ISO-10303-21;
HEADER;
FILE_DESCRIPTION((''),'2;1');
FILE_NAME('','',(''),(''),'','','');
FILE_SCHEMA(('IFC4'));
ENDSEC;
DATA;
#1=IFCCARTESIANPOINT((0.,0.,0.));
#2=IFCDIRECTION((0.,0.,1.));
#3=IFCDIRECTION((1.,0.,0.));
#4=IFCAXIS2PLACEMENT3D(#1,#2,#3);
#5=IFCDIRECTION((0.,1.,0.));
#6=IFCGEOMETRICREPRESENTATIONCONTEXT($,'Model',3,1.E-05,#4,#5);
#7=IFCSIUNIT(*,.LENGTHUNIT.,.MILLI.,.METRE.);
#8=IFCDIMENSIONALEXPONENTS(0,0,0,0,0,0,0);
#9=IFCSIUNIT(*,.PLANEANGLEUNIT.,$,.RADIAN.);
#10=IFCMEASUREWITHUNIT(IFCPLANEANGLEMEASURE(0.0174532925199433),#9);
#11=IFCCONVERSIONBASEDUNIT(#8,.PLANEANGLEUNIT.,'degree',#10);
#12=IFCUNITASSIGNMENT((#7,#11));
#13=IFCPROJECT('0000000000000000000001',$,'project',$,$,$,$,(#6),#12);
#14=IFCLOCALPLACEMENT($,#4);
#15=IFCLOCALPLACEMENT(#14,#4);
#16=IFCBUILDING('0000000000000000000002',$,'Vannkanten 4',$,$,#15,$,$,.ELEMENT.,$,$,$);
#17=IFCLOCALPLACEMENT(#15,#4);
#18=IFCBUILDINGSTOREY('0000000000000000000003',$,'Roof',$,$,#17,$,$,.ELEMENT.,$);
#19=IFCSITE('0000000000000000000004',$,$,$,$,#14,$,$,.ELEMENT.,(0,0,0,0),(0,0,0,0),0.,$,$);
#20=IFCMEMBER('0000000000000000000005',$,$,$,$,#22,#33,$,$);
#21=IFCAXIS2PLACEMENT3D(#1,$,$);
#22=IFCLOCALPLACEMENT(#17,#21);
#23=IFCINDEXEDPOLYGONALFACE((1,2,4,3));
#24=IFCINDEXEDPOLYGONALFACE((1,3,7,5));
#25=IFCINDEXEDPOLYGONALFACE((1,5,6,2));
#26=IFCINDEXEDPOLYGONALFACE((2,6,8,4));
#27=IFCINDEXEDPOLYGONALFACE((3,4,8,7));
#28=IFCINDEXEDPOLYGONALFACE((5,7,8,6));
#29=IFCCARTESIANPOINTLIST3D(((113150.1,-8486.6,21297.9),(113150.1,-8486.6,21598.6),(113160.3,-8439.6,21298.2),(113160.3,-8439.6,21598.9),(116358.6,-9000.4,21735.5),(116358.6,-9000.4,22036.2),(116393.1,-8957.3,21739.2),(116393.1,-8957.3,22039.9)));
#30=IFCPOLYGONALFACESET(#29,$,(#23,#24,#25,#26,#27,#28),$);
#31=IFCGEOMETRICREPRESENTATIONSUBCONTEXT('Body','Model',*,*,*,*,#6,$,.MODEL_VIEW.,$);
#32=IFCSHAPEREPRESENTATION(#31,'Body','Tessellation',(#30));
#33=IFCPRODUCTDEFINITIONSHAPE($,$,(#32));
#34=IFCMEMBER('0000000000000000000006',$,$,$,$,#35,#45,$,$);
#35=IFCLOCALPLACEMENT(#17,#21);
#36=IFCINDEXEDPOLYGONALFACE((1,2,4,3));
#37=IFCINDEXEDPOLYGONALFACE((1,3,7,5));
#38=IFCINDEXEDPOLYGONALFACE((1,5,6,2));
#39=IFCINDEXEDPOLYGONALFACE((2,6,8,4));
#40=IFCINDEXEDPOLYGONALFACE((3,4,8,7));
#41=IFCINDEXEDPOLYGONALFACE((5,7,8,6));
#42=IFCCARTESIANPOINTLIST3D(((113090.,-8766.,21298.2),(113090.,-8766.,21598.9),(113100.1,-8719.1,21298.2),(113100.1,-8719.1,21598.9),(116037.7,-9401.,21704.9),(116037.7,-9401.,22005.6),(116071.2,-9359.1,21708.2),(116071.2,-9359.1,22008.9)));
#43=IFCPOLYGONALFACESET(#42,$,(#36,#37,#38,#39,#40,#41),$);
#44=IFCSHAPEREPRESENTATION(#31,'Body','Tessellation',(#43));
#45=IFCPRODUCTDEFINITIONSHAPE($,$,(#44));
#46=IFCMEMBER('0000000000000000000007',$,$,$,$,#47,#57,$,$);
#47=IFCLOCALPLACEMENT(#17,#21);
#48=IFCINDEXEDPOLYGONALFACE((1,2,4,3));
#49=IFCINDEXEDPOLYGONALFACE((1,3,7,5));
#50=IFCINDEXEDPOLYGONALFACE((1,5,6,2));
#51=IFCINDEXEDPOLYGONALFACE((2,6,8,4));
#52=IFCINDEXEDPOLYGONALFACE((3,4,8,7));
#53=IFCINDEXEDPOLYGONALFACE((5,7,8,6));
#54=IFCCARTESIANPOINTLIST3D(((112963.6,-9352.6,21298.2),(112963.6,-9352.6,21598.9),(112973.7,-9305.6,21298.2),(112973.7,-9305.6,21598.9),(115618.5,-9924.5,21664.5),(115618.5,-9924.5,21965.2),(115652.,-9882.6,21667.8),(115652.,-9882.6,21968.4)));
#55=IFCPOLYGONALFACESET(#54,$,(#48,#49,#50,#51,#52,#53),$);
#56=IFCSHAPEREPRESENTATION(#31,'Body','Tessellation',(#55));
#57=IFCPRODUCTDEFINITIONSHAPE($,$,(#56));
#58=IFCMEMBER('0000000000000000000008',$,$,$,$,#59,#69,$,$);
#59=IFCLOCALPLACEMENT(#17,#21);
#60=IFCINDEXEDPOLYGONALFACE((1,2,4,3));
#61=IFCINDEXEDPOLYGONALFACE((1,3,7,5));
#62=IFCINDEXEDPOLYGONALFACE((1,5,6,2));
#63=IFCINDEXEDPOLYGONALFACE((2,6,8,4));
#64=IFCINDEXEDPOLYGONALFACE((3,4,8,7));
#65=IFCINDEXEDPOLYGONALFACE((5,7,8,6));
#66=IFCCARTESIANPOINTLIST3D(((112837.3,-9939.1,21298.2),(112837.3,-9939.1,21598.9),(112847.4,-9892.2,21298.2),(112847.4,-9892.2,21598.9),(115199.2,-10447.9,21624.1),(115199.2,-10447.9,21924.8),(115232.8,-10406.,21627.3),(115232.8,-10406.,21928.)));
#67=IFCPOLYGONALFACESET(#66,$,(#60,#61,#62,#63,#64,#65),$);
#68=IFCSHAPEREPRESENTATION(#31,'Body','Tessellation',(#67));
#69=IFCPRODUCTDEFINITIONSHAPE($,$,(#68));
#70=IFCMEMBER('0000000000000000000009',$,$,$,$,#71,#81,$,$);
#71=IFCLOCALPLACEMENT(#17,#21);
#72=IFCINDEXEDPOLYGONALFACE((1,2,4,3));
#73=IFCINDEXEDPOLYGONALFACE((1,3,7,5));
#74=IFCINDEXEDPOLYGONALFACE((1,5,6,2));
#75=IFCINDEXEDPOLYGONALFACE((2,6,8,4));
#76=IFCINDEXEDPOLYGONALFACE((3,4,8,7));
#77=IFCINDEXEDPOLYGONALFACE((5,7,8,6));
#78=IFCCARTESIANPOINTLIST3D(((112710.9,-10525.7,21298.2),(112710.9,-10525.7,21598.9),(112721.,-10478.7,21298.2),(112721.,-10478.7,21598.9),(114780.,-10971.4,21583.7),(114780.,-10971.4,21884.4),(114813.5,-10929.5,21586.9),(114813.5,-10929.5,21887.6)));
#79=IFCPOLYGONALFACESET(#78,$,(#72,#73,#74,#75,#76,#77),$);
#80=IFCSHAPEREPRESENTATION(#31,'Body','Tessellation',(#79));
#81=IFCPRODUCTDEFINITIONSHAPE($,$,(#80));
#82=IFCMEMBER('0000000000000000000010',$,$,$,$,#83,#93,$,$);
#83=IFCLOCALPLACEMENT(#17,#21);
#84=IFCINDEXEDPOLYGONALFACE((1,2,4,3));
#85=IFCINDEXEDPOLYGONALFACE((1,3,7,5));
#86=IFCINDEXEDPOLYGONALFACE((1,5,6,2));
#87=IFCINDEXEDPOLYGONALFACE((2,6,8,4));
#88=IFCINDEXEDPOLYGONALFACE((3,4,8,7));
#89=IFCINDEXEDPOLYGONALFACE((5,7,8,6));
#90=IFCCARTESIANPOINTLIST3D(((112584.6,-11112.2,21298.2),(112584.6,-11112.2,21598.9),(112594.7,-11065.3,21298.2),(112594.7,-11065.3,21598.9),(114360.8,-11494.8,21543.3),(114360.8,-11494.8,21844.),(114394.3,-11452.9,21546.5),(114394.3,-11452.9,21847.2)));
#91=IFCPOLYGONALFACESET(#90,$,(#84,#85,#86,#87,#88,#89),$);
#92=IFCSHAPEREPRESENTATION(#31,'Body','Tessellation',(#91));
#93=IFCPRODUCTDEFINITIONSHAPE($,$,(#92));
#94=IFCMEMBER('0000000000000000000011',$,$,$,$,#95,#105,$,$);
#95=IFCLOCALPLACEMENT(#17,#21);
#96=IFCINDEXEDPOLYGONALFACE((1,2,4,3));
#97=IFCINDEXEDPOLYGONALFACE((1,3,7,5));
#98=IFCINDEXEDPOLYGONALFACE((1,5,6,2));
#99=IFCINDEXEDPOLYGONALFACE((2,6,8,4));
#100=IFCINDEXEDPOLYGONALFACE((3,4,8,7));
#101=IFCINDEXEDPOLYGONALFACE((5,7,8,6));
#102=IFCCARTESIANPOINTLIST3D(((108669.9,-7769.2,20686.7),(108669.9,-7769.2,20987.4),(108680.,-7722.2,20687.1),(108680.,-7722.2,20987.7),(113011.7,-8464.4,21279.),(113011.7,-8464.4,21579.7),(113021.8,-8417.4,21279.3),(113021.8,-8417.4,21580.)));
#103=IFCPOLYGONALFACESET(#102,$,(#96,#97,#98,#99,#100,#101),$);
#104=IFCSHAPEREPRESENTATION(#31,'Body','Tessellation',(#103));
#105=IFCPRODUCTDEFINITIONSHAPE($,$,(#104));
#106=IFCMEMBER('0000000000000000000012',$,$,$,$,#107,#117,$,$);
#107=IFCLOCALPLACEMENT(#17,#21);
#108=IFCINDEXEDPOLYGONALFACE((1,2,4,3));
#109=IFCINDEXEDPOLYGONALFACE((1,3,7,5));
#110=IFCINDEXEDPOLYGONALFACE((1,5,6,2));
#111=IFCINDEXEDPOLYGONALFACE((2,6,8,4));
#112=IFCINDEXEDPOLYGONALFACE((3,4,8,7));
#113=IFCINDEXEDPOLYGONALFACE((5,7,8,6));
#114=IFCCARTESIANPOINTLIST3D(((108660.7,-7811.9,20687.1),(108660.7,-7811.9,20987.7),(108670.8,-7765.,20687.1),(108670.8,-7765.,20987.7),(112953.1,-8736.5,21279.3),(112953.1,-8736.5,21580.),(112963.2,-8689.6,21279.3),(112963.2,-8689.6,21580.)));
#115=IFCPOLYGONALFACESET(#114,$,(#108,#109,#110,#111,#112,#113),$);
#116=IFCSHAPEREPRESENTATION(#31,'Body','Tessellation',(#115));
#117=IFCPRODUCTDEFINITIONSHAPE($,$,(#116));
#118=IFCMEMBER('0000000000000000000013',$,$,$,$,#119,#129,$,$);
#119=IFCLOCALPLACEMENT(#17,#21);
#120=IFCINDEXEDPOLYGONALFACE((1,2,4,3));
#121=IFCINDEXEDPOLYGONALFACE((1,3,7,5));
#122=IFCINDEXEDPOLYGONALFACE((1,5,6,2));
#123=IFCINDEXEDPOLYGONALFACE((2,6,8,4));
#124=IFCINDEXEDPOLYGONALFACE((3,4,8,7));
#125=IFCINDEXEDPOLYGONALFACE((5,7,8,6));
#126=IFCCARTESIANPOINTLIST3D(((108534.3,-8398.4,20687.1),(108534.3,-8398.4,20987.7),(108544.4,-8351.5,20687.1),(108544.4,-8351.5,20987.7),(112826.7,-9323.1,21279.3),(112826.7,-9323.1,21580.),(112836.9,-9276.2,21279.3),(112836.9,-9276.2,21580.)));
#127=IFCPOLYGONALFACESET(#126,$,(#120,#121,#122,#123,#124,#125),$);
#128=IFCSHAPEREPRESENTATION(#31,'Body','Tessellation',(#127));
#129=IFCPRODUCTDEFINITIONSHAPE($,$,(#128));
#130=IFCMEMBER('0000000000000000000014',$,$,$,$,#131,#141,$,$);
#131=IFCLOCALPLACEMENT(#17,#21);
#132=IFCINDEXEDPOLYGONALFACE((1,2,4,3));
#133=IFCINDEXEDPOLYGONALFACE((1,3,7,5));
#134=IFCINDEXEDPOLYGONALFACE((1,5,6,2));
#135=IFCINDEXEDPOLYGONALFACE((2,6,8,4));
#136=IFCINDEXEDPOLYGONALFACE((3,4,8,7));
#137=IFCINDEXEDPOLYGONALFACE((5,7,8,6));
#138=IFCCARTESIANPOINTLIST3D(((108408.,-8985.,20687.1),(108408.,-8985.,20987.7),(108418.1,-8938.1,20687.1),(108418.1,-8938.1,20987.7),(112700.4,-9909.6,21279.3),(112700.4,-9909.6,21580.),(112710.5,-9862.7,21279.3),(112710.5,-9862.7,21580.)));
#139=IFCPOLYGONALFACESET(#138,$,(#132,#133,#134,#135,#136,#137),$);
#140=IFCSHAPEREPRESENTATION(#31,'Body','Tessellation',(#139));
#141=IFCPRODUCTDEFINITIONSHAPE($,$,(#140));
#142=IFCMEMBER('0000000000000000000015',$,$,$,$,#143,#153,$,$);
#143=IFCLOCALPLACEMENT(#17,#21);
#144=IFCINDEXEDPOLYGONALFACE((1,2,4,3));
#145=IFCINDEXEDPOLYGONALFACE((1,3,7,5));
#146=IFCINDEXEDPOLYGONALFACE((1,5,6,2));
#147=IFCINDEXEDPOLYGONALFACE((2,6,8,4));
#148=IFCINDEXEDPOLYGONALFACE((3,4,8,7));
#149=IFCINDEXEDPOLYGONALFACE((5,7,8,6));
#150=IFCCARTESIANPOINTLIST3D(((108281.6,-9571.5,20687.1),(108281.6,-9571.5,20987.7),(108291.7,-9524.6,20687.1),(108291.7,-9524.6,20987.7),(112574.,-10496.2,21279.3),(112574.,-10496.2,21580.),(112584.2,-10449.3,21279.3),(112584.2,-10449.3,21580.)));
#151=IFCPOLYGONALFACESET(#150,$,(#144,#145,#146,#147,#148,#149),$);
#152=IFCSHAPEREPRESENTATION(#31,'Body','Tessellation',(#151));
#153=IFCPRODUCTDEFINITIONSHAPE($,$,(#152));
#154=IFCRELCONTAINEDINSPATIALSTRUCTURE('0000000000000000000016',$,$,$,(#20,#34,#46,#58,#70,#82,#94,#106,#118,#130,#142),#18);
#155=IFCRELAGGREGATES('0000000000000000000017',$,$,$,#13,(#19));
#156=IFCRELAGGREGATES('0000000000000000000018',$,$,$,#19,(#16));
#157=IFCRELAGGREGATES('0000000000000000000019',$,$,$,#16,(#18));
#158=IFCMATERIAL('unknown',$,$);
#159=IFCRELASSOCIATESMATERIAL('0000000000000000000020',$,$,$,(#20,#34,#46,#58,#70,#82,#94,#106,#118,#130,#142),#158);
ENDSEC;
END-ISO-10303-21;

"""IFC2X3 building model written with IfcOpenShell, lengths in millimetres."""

from ifc_helpers import new_model, entity, si_unit, converted_unit, direction, frame, origin_with_axes, place, context, subcontext, project, spatial, polyline, segment, composite_curve, outline, extrude, clip, halfspace, material, element, save


model = new_model("IFC2X3")

# Units and contexts
model_context = context("Model", 3, precision=1e-05, world=origin_with_axes(), true_north=direction((0.0, 1.0, 0.0)))
body_context = subcontext(model_context, "Body", "Model", "MODEL_VIEW")
ifc_project = project(units=[si_unit("LENGTHUNIT", "METRE", prefix="MILLI"), converted_unit("PLANEANGLEUNIT", "degree", entity("IfcPlaneAngleMeasure", 0.0174532925199433), si_unit("PLANEANGLEUNIT", "RADIAN"), dimensions=[0, 0, 0, 0, 0, 0, 0])], contexts=[model_context])

# Site, building, storey
site_placement = place(None, origin_with_axes())
site = spatial("IfcSite", under=ifc_project, at=site_placement, CompositionType="ELEMENT", RefLatitude=(0, 0, 0, 0), RefLongitude=(0, 0, 0, 0), RefElevation=0.0)
building_placement = place(site_placement, origin_with_axes())
building = spatial("IfcBuilding", under=site, at=building_placement, Name="Vannkanten 4", CompositionType="ELEMENT")
storey_placement = place(building_placement, origin_with_axes())
storey = spatial("IfcBuildingStorey", under=building, at=storey_placement, Name="Roof", CompositionType="ELEMENT")

# Members
ifc_material = material(Name="unknown")
member_1_placement = place(storey_placement, frame((113155.2, -8463.1, 21448.4), z_axis=(0.978583, -0.156701, 0.133488), x_axis=(0.158117, 0.98742, 0.0)))
element("IfcMember", 1, at=member_1_placement, inside=storey, material=ifc_material, context=body_context, shape_type="Clipping", body=[
    clip(clip(extrude(outline(composite_curve([segment(polyline([(-24.0, -149.0), (-24.0, 149.0), (24.0, 149.0), (24.0, -149.0), (-24.0, -149.0)]), True, "CONTINUOUS")], self_intersect=False)), frame((0.0, 0.0, -1694.5), z_axis=(0.0, 0.0, 1.0), x_axis=(1.0, 0.0, 0.0)), (0.0, 0.0, 1.0), 6692.5), halfspace(frame((-24.0, 149.0, 18.8), z_axis=(-0.053362, -0.133298, 0.989638), x_axis=(0.0, 0.99105, 0.133488)), True)), halfspace(frame((24.0, 149.0, 3324.9), z_axis=(0.493845, 0.116074, -0.861768), x_axis=(-0.867633, 0.0, -0.497206)), True)),
])
member_2_placement = place(storey_placement, frame((113095.0, -8742.6, 21448.6), z_axis=(0.968803, -0.208692, 0.133675), x_axis=(0.210582, 0.977576, 0.0)))
element("IfcMember", 2, at=member_2_placement, inside=storey, material=ifc_material, context=body_context, shape_type="Clipping", body=[
    clip(clip(extrude(outline(composite_curve([segment(polyline([(-24.0, -149.0), (-24.0, 149.0), (24.0, 149.0), (24.0, -149.0), (-24.0, -149.0)]), True, "CONTINUOUS")], self_intersect=False)), frame((0.0, 0.0, -1573.6), z_axis=(0.0, 0.0, 1.0), x_axis=(1.0, 0.0, 0.0)), (0.0, 0.0, 1.0), 6214.1), halfspace(frame((-24.0, 149.0, 20.1), z_axis=(0.0, -0.133675, 0.991025), x_axis=(0.0, 0.991025, 0.133675)), True)), halfspace(frame((24.0, 149.0, 3086.9), z_axis=(0.446741, 0.119594, -0.886634), x_axis=(-0.893044, 0.0, -0.44997)), True)),
])
member_3_placement = place(storey_placement, frame((112968.7, -9329.1, 21448.6), z_axis=(0.968803, -0.208692, 0.133675), x_axis=(0.210582, 0.977576, 0.0)))
element("IfcMember", 3, at=member_3_placement, inside=storey, material=ifc_material, context=body_context, shape_type="Clipping", body=[
    clip(clip(extrude(outline(composite_curve([segment(polyline([(-24.0, -149.0), (-24.0, 149.0), (24.0, 149.0), (24.0, -149.0), (-24.0, -149.0)]), True, "CONTINUOUS")], self_intersect=False)), frame((0.0, 0.0, -1422.5), z_axis=(0.0, 0.0, 1.0), x_axis=(1.0, 0.0, 0.0)), (0.0, 0.0, 1.0), 5609.4), halfspace(frame((-24.0, 149.0, 20.1), z_axis=(0.0, -0.133675, 0.991025), x_axis=(0.0, 0.991025, 0.133675)), True)), halfspace(frame((24.0, 149.0, 2784.6), z_axis=(0.446741, 0.119594, -0.886634), x_axis=(-0.893044, 0.0, -0.44997)), True)),
])
member_4_placement = place(storey_placement, frame((112842.3, -9915.7, 21448.6), z_axis=(0.968803, -0.208692, 0.133675), x_axis=(0.210582, 0.977576, 0.0)))
element("IfcMember", 4, at=member_4_placement, inside=storey, material=ifc_material, context=body_context, shape_type="Clipping", body=[
    clip(clip(extrude(outline(composite_curve([segment(polyline([(-24.0, -149.0), (-24.0, 149.0), (24.0, 149.0), (24.0, -149.0), (-24.0, -149.0)]), True, "CONTINUOUS")], self_intersect=False)), frame((0.0, 0.0, -1271.3), z_axis=(0.0, 0.0, 1.0), x_axis=(1.0, 0.0, 0.0)), (0.0, 0.0, 1.0), 5004.8), halfspace(frame((-24.0, 149.0, 20.1), z_axis=(0.0, -0.133675, 0.991025), x_axis=(0.0, 0.991025, 0.133675)), True)), halfspace(frame((24.0, 149.0, 2482.3), z_axis=(0.446741, 0.119594, -0.886634), x_axis=(-0.893044, 0.0, -0.44997)), True)),
])
member_5_placement = place(storey_placement, frame((112716.0, -10502.2, 21448.6), z_axis=(0.968803, -0.208692, 0.133675), x_axis=(0.210582, 0.977576, 0.0)))
element("IfcMember", 5, at=member_5_placement, inside=storey, material=ifc_material, context=body_context, shape_type="Clipping", body=[
    clip(clip(extrude(outline(composite_curve([segment(polyline([(-24.0, -149.0), (-24.0, 149.0), (24.0, 149.0), (24.0, -149.0), (-24.0, -149.0)]), True, "CONTINUOUS")], self_intersect=False)), frame((0.0, 0.0, -1120.1), z_axis=(0.0, 0.0, 1.0), x_axis=(1.0, 0.0, 0.0)), (0.0, 0.0, 1.0), 4400.2), halfspace(frame((-24.0, 149.0, 20.1), z_axis=(0.0, -0.133675, 0.991025), x_axis=(0.0, 0.991025, 0.133675)), True)), halfspace(frame((24.0, 149.0, 2180.0), z_axis=(0.446741, 0.119594, -0.886634), x_axis=(-0.893044, 0.0, -0.44997)), True)),
])
member_6_placement = place(storey_placement, frame((112589.6, -11088.7, 21448.6), z_axis=(0.968803, -0.208692, 0.133675), x_axis=(0.210582, 0.977576, 0.0)))
element("IfcMember", 6, at=member_6_placement, inside=storey, material=ifc_material, context=body_context, shape_type="Clipping", body=[
    clip(clip(extrude(outline(composite_curve([segment(polyline([(-24.0, -149.0), (-24.0, 149.0), (24.0, 149.0), (24.0, -149.0), (-24.0, -149.0)]), True, "CONTINUOUS")], self_intersect=False)), frame((0.0, 0.0, -969.0), z_axis=(0.0, 0.0, 1.0), x_axis=(1.0, 0.0, 0.0)), (0.0, 0.0, 1.0), 3795.5), halfspace(frame((-24.0, 149.0, 20.1), z_axis=(0.0, -0.133675, 0.991025), x_axis=(0.0, 0.991025, 0.133675)), True)), halfspace(frame((24.0, 149.0, 1877.7), z_axis=(0.446741, 0.119594, -0.886634), x_axis=(-0.893044, 0.0, -0.44997)), True)),
])
member_7_placement = place(storey_placement, frame((108674.9, -7745.7, 20837.2), z_axis=(0.978583, -0.156701, 0.133488), x_axis=(0.158117, 0.98742, 0.0)))
element("IfcMember", 7, at=member_7_placement, inside=storey, material=ifc_material, context=body_context, shape_type="Clipping", body=[
    clip(clip(extrude(outline(composite_curve([segment(polyline([(-24.0, -149.0), (-24.0, 149.0), (24.0, 149.0), (24.0, -149.0), (-24.0, -149.0)]), True, "CONTINUOUS")], self_intersect=False)), frame((0.0, 0.0, -2261.2), z_axis=(0.0, 0.0, 1.0), x_axis=(1.0, 0.0, 0.0)), (0.0, 0.0, 1.0), 8959.2), halfspace(frame((-24.0, 149.0, 18.8), z_axis=(-0.053362, -0.133298, 0.989638), x_axis=(0.0, 0.99105, 0.133488)), True)), halfspace(frame((24.0, 149.0, 4458.2), z_axis=(0.053362, 0.133298, -0.989638), x_axis=(0.0, -0.99105, -0.133488)), True)),
])
member_8_placement = place(storey_placement, frame((108665.7, -7788.4, 20837.4), z_axis=(0.968803, -0.208692, 0.133675), x_axis=(0.210582, 0.977576, 0.0)))
element("IfcMember", 8, at=member_8_placement, inside=storey, material=ifc_material, context=body_context, shape_type="Clipping", body=[
    clip(clip(extrude(outline(composite_curve([segment(polyline([(-24.0, -149.0), (-24.0, 149.0), (24.0, 149.0), (24.0, -149.0), (-24.0, -149.0)]), True, "CONTINUOUS")], self_intersect=False)), frame((0.0, 0.0, -2255.5), z_axis=(0.0, 0.0, 1.0), x_axis=(1.0, 0.0, 0.0)), (0.0, 0.0, 1.0), 8941.7), halfspace(frame((-24.0, 149.0, 20.1), z_axis=(0.0, -0.133675, 0.991025), x_axis=(0.0, 0.991025, 0.133675)), True)), halfspace(frame((24.0, 149.0, 4450.8), z_axis=(0.0, 0.133675, -0.991025), x_axis=(0.0, -0.991025, -0.133675)), True)),
])
member_9_placement = place(storey_placement, frame((108539.4, -8375.0, 20837.4), z_axis=(0.968803, -0.208692, 0.133675), x_axis=(0.210582, 0.977576, 0.0)))
element("IfcMember", 9, at=member_9_placement, inside=storey, material=ifc_material, context=body_context, shape_type="Clipping", body=[
    clip(clip(extrude(outline(composite_curve([segment(polyline([(-24.0, -149.0), (-24.0, 149.0), (24.0, 149.0), (24.0, -149.0), (-24.0, -149.0)]), True, "CONTINUOUS")], self_intersect=False)), frame((0.0, 0.0, -2255.5), z_axis=(0.0, 0.0, 1.0), x_axis=(1.0, 0.0, 0.0)), (0.0, 0.0, 1.0), 8941.7), halfspace(frame((-24.0, 149.0, 20.1), z_axis=(0.0, -0.133675, 0.991025), x_axis=(0.0, 0.991025, 0.133675)), True)), halfspace(frame((24.0, 149.0, 4450.8), z_axis=(0.0, 0.133675, -0.991025), x_axis=(0.0, -0.991025, -0.133675)), True)),
])
member_10_placement = place(storey_placement, frame((108413.0, -8961.5, 20837.4), z_axis=(0.968803, -0.208692, 0.133675), x_axis=(0.210582, 0.977576, 0.0)))
element("IfcMember", 10, at=member_10_placement, inside=storey, material=ifc_material, context=body_context, shape_type="Clipping", body=[
    clip(clip(extrude(outline(composite_curve([segment(polyline([(-24.0, -149.0), (-24.0, 149.0), (24.0, 149.0), (24.0, -149.0), (-24.0, -149.0)]), True, "CONTINUOUS")], self_intersect=False)), frame((0.0, 0.0, -2255.5), z_axis=(0.0, 0.0, 1.0), x_axis=(1.0, 0.0, 0.0)), (0.0, 0.0, 1.0), 8941.7), halfspace(frame((-24.0, 149.0, 20.1), z_axis=(0.0, -0.133675, 0.991025), x_axis=(0.0, 0.991025, 0.133675)), True)), halfspace(frame((24.0, 149.0, 4450.8), z_axis=(0.0, 0.133675, -0.991025), x_axis=(0.0, -0.991025, -0.133675)), True)),
])
member_11_placement = place(storey_placement, frame((108286.7, -9548.1, 20837.4), z_axis=(0.968803, -0.208692, 0.133675), x_axis=(0.210582, 0.977576, 0.0)))
element("IfcMember", 11, at=member_11_placement, inside=storey, material=ifc_material, context=body_context, shape_type="Clipping", body=[
    clip(clip(extrude(outline(composite_curve([segment(polyline([(-24.0, -149.0), (-24.0, 149.0), (24.0, 149.0), (24.0, -149.0), (-24.0, -149.0)]), True, "CONTINUOUS")], self_intersect=False)), frame((0.0, 0.0, -2255.5), z_axis=(0.0, 0.0, 1.0), x_axis=(1.0, 0.0, 0.0)), (0.0, 0.0, 1.0), 8941.7), halfspace(frame((-24.0, 149.0, 20.1), z_axis=(0.0, -0.133675, 0.991025), x_axis=(0.0, 0.991025, 0.133675)), True)), halfspace(frame((24.0, 149.0, 4450.8), z_axis=(0.0, 0.133675, -0.991025), x_axis=(0.0, -0.991025, -0.133675)), True)),
])

save(model, "model.ifc")
